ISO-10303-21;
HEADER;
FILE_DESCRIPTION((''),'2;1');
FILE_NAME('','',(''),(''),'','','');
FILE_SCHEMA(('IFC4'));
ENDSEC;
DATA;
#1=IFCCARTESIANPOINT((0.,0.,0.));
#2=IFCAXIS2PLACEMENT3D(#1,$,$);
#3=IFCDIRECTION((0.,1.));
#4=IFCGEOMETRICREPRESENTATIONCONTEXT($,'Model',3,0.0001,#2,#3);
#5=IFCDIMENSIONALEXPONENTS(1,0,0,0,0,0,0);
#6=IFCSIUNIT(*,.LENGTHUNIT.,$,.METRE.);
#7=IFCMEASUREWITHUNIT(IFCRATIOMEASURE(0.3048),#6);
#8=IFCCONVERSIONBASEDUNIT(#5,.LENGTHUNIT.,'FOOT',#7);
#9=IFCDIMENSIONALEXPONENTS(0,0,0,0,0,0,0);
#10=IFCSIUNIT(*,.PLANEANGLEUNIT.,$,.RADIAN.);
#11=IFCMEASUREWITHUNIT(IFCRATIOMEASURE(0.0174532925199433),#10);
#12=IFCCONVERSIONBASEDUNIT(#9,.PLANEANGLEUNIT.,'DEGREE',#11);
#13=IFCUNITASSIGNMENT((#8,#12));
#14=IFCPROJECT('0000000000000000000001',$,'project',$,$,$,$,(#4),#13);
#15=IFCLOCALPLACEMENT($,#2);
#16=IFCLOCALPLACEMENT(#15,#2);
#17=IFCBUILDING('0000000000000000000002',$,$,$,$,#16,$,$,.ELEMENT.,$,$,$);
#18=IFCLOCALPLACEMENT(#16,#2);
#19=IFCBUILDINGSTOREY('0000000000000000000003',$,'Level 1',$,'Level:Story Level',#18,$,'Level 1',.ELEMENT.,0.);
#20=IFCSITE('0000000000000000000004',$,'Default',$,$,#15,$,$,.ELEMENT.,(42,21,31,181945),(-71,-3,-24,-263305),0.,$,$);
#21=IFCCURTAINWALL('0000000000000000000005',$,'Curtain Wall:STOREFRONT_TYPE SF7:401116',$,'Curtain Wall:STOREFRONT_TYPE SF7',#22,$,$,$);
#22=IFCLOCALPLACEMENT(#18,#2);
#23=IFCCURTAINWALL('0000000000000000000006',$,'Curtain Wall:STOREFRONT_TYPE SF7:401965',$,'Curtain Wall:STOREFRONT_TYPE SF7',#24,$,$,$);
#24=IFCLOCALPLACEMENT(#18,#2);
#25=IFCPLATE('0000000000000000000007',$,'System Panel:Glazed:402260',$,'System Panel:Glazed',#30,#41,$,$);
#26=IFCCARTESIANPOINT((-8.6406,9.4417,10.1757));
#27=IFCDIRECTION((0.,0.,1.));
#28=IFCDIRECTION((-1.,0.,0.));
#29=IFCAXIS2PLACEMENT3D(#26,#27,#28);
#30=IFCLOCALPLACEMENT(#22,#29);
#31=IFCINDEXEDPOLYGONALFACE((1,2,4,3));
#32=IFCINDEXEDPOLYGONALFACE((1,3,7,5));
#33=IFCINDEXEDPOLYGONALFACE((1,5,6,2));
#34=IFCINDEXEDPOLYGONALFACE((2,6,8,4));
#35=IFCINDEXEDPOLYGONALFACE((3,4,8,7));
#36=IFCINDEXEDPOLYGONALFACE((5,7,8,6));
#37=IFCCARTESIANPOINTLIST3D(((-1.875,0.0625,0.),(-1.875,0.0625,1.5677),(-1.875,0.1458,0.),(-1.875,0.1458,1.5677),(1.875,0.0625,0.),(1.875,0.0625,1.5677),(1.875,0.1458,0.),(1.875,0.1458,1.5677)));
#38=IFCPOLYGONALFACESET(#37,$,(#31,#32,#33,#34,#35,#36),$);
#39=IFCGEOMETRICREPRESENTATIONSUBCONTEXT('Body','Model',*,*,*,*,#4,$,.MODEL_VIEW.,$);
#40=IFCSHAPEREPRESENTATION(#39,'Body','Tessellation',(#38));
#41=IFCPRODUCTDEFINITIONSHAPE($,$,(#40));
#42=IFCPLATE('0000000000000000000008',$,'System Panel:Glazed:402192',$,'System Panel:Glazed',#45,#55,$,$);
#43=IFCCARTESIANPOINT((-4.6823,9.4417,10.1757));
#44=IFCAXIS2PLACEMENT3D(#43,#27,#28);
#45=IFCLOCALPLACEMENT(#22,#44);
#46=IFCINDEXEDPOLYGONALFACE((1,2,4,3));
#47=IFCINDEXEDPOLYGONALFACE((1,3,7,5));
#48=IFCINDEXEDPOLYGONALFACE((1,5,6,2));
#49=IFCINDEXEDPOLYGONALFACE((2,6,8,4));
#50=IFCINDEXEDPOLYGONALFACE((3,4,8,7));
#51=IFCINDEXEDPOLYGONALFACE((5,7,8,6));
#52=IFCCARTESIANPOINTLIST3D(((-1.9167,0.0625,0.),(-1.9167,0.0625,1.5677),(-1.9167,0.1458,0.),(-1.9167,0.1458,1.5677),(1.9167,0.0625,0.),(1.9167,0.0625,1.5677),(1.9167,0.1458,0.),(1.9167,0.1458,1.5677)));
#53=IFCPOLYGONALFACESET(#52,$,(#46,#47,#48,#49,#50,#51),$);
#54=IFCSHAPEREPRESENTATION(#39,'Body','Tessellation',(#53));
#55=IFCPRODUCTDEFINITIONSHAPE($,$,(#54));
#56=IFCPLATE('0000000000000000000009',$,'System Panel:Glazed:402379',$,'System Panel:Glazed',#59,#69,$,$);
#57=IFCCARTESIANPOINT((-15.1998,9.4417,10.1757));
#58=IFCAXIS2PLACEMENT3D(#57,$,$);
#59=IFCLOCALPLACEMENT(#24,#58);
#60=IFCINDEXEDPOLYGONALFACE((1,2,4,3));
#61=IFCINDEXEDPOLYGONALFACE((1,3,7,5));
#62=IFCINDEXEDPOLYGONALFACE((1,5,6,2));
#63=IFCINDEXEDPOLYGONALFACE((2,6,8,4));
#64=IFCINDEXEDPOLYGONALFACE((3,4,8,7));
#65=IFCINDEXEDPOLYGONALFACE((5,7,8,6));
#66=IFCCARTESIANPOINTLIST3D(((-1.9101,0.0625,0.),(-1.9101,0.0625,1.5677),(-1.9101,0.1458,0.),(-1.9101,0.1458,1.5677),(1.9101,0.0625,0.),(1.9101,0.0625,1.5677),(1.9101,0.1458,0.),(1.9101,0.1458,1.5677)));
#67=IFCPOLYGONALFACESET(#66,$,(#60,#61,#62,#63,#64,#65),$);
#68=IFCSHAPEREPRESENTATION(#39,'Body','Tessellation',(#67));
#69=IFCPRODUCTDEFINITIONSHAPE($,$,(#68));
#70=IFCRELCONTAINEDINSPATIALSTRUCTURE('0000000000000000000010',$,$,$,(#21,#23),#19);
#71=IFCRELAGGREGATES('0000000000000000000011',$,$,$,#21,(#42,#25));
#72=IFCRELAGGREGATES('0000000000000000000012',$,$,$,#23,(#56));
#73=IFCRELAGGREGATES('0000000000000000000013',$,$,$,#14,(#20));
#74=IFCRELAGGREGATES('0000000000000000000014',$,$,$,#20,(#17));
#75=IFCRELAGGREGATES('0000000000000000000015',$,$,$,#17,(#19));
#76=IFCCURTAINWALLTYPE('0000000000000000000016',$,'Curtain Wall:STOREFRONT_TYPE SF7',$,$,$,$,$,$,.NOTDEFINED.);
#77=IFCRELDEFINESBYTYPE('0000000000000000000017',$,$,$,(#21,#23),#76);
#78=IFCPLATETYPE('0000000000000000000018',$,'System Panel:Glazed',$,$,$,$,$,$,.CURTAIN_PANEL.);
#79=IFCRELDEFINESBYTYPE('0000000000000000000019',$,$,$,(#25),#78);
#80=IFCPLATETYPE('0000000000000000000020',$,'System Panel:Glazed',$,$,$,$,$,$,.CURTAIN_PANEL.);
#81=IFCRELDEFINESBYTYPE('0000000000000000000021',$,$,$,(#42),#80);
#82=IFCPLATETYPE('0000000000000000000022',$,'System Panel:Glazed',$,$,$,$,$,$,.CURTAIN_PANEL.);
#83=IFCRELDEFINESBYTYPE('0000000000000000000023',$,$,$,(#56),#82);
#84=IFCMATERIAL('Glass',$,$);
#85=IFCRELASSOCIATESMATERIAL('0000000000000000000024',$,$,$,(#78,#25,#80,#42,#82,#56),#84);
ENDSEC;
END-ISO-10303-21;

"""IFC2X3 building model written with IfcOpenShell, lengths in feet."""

from ifc_helpers import new_model, entity, si_unit, converted_unit, direction, frame, frame_2d, origin, place, context, subcontext, project, spatial, rectangle, extrude, source, transform, mapped, material, type_object, type_shapes, element, aggregate, save


model = new_model("IFC2X3")

# Units and contexts
model_context = context("Model", 3, precision=0.0001, world=origin(), true_north=direction((0.0, 1.0)))
body_context = subcontext(model_context, "Body", "Model", "MODEL_VIEW")
ifc_project = project(units=[converted_unit("LENGTHUNIT", "FOOT", entity("IfcRatioMeasure", 0.3048), si_unit("LENGTHUNIT", "METRE"), dimensions=[1, 0, 0, 0, 0, 0, 0]), converted_unit("PLANEANGLEUNIT", "DEGREE", entity("IfcRatioMeasure", 0.0174532925199433), si_unit("PLANEANGLEUNIT", "RADIAN"), dimensions=[0, 0, 0, 0, 0, 0, 0])], contexts=[model_context])

# Site, building, storey
site_placement = place(None, origin())
site = spatial("IfcSite", under=ifc_project, at=site_placement, Name="Default", CompositionType="ELEMENT", RefLatitude=(42, 21, 31, 181945), RefLongitude=(-71, -3, -24, -263305), RefElevation=0.0)
building_placement = place(site_placement, origin())
building = spatial("IfcBuilding", under=site, at=building_placement, CompositionType="ELEMENT")
storey_placement = place(building_placement, origin())
storey = spatial("IfcBuildingStorey", under=building, at=storey_placement, Name="Level 1", ObjectType="Level:Story Level", LongName="Level 1", CompositionType="ELEMENT", Elevation=0.0)

# Curtain wall
curtain_wall_type = type_object("IfcCurtainWallType", Name="Curtain Wall:STOREFRONT_TYPE SF7", PredefinedType="NOTDEFINED")
curtain_wall_1_placement = place(storey_placement, origin())
curtain_wall_1 = element("IfcCurtainWall", 1, at=curtain_wall_1_placement, inside=storey, type_object=curtain_wall_type, Name="Curtain Wall:STOREFRONT_TYPE SF7:401116", ObjectType="Curtain Wall:STOREFRONT_TYPE SF7")

# Curtain wall
curtain_wall_2_placement = place(storey_placement, origin())
curtain_wall_2 = element("IfcCurtainWall", 2, at=curtain_wall_2_placement, inside=storey, type_object=curtain_wall_type, Name="Curtain Wall:STOREFRONT_TYPE SF7:401965", ObjectType="Curtain Wall:STOREFRONT_TYPE SF7")

# Plates
ifc_material_1 = material(Name="Glass")
plate_type_1 = type_object("IfcPlateType", Name="System Panel:Glazed", PredefinedType="CURTAIN_PANEL", material=ifc_material_1)
shared_shape_1 = source(origin(), body_context, "Body", "SweptSolid", [
    extrude(rectangle(XDim=0.0833, YDim=3.75, at=frame_2d((0.0, 0.0), x_axis=(1.0, 0.0))), frame((0.0, 0.1042, 0.0), z_axis=(0.0, 0.0, 1.0), x_axis=(0.0, 1.0, 0.0)), (0.0, 0.0, 1.0), 1.5677),
])
type_shapes(plate_type_1, [shared_shape_1])
plate_1_placement = place(curtain_wall_1_placement, frame((-8.6406, 9.4417, 10.1757), z_axis=(0.0, 0.0, 1.0), x_axis=(-1.0, 0.0, 0.0)))
plate_1 = element("IfcPlate", 3, at=plate_1_placement, type_object=plate_type_1, material=ifc_material_1, Name="System Panel:Glazed:402260", ObjectType="System Panel:Glazed", context=body_context, shape_type="MappedRepresentation", body=[
    mapped(shared_shape_1, transform((0.0, 0.0, 0.0), scale=1.0)),
])
plate_type_2 = type_object("IfcPlateType", Name="System Panel:Glazed", PredefinedType="CURTAIN_PANEL", material=ifc_material_1)
shared_shape_2 = source(origin(), body_context, "Body", "SweptSolid", [
    extrude(rectangle(XDim=0.0833, YDim=3.8333, at=frame_2d((0.0, 0.0), x_axis=(1.0, 0.0))), frame((0.0, 0.1042, 0.0), z_axis=(0.0, 0.0, 1.0), x_axis=(0.0, 1.0, 0.0)), (0.0, 0.0, 1.0), 1.5677),
])
type_shapes(plate_type_2, [shared_shape_2])
plate_2_placement = place(curtain_wall_1_placement, frame((-4.6823, 9.4417, 10.1757), z_axis=(0.0, 0.0, 1.0), x_axis=(-1.0, 0.0, 0.0)))
plate_2 = element("IfcPlate", 4, at=plate_2_placement, type_object=plate_type_2, material=ifc_material_1, Name="System Panel:Glazed:402192", ObjectType="System Panel:Glazed", context=body_context, shape_type="MappedRepresentation", body=[
    mapped(shared_shape_2, transform((0.0, 0.0, 0.0), scale=1.0)),
])
aggregate(curtain_wall_1, [plate_2, plate_1])
plate_type_3 = type_object("IfcPlateType", Name="System Panel:Glazed", PredefinedType="CURTAIN_PANEL", material=ifc_material_1)
shared_shape_3 = source(origin(), body_context, "Body", "SweptSolid", [
    extrude(rectangle(XDim=0.0833, YDim=3.8202, at=frame_2d((0.0, 0.0), x_axis=(1.0, 0.0))), frame((0.0, 0.1042, 0.0), z_axis=(0.0, 0.0, 1.0), x_axis=(0.0, 1.0, 0.0)), (0.0, 0.0, 1.0), 1.5677),
])
type_shapes(plate_type_3, [shared_shape_3])
plate_3_placement = place(curtain_wall_2_placement, frame((-15.1998, 9.4417, 10.1757)))
plate_3 = element("IfcPlate", 5, at=plate_3_placement, type_object=plate_type_3, material=ifc_material_1, Name="System Panel:Glazed:402379", ObjectType="System Panel:Glazed", context=body_context, shape_type="MappedRepresentation", body=[
    mapped(shared_shape_3, transform((0.0, 0.0, 0.0), scale=1.0)),
])
aggregate(curtain_wall_2, [plate_3])

save(model, "model.ifc")
